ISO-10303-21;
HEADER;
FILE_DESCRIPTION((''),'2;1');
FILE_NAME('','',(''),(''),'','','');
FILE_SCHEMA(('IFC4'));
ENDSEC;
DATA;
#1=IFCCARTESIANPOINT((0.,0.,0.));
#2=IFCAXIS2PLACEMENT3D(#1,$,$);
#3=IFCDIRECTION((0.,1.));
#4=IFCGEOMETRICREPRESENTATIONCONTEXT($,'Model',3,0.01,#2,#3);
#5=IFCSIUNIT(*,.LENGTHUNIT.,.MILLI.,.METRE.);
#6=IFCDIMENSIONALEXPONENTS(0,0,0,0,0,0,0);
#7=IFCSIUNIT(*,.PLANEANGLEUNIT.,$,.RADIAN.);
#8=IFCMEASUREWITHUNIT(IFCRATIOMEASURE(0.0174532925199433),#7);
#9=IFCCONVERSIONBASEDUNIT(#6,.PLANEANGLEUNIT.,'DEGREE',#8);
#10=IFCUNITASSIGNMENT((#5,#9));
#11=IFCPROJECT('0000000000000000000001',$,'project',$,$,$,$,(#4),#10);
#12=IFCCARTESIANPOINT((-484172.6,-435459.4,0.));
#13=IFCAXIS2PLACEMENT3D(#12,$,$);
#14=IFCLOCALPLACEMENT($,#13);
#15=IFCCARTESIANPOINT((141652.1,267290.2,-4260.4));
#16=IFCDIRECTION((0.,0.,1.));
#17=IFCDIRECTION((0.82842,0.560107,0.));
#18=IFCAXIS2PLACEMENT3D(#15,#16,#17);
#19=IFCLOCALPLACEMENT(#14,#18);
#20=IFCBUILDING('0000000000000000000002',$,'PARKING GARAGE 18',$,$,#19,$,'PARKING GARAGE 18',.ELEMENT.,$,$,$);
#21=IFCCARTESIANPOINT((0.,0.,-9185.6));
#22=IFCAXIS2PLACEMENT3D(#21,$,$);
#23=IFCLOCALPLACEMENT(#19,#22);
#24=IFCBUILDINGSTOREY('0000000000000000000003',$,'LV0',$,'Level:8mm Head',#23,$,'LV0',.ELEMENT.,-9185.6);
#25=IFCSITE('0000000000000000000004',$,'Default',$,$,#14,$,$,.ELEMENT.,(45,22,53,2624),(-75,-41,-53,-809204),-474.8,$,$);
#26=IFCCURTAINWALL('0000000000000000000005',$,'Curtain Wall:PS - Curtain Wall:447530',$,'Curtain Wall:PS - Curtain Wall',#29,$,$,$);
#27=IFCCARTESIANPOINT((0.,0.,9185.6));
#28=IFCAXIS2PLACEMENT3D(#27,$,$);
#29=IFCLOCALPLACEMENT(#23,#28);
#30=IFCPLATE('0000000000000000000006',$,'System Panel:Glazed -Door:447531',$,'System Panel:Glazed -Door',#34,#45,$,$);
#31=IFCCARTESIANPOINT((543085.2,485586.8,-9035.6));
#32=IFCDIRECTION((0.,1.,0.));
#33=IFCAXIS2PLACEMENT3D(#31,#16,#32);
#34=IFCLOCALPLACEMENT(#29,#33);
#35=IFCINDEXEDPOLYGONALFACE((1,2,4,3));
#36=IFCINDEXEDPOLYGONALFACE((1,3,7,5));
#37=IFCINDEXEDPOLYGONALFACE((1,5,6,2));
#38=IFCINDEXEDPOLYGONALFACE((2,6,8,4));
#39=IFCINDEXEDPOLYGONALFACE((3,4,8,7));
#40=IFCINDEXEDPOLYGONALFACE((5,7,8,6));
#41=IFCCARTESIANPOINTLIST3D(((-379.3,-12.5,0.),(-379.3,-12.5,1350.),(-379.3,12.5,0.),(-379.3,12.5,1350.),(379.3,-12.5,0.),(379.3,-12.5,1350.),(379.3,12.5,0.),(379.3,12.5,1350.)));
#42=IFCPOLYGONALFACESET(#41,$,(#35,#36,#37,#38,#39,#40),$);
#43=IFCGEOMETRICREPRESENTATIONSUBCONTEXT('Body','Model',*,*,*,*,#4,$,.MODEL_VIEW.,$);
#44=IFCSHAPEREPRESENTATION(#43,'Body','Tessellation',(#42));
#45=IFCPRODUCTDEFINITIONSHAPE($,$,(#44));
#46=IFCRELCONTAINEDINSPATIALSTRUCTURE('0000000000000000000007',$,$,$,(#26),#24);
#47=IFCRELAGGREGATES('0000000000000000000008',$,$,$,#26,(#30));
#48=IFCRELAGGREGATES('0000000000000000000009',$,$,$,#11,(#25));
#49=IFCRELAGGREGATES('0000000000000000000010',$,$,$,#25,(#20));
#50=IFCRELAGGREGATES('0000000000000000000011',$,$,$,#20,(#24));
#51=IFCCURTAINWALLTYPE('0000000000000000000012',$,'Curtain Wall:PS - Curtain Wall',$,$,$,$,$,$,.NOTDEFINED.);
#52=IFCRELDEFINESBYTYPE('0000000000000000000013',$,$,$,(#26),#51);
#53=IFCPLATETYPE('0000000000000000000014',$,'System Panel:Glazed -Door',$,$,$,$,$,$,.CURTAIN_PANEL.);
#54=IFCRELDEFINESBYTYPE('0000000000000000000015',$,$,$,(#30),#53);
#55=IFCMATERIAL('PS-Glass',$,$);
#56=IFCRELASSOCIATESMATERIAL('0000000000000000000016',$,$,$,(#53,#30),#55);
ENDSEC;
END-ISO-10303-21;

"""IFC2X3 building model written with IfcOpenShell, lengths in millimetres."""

from ifc_helpers import new_model, entity, si_unit, converted_unit, direction, frame, origin, origin_2d_with_axis, place, context, subcontext, project, spatial, rectangle, extrude, source, transform, mapped, material, type_object, type_shapes, element, aggregate, save


model = new_model("IFC2X3")

# Units and contexts
model_context = context("Model", 3, precision=0.01, world=origin(), true_north=direction((0.0, 1.0)))
body_context = subcontext(model_context, "Body", "Model", "MODEL_VIEW")
ifc_project = project(units=[si_unit("LENGTHUNIT", "METRE", prefix="MILLI"), converted_unit("PLANEANGLEUNIT", "DEGREE", entity("IfcRatioMeasure", 0.0174532925199433), si_unit("PLANEANGLEUNIT", "RADIAN"), dimensions=[0, 0, 0, 0, 0, 0, 0])], contexts=[model_context])

# Site, building, storey
site_placement = place(None, frame((-484172.6, -435459.4, 0.0)))
site = spatial("IfcSite", under=ifc_project, at=site_placement, Name="Default", CompositionType="ELEMENT", RefLatitude=(45, 22, 53, 2624), RefLongitude=(-75, -41, -53, -809204), RefElevation=-474.8)
building_placement = place(site_placement, frame((141652.1, 267290.2, -4260.4), z_axis=(0.0, 0.0, 1.0), x_axis=(0.82842, 0.560107, 0.0)))
building = spatial("IfcBuilding", under=site, at=building_placement, Name="PARKING GARAGE 18", LongName="PARKING GARAGE 18", CompositionType="ELEMENT")
storey_placement = place(building_placement, frame((0.0, 0.0, -9185.6)))
storey = spatial("IfcBuildingStorey", under=building, at=storey_placement, Name="LV0", ObjectType="Level:8mm Head", LongName="LV0", CompositionType="ELEMENT", Elevation=-9185.6)

# Curtain wall, plate
curtain_wall_type = type_object("IfcCurtainWallType", Name="Curtain Wall:PS - Curtain Wall", PredefinedType="NOTDEFINED")
curtain_wall_placement = place(storey_placement, frame((0.0, 0.0, 9185.6)))
curtain_wall = element("IfcCurtainWall", 1, at=curtain_wall_placement, inside=storey, type_object=curtain_wall_type, Name="Curtain Wall:PS - Curtain Wall:447530", ObjectType="Curtain Wall:PS - Curtain Wall")
ifc_material_1 = material(Name="PS-Glass")
plate_type = type_object("IfcPlateType", Name="System Panel:Glazed -Door", PredefinedType="CURTAIN_PANEL", material=ifc_material_1)
shared_shape = source(origin(), body_context, "Body", "SweptSolid", [
    extrude(rectangle(XDim=25.0, YDim=758.7, at=origin_2d_with_axis()), frame((0.0, 0.0, 0.0), z_axis=(0.0, 0.0, 1.0), x_axis=(0.0, 1.0, 0.0)), (0.0, 0.0, 1.0), 1350.0),
])
type_shapes(plate_type, [shared_shape])
plate_placement = place(curtain_wall_placement, frame((543085.2, 485586.8, -9035.6), z_axis=(0.0, 0.0, 1.0), x_axis=(0.0, 1.0, 0.0)))
plate = element("IfcPlate", 2, at=plate_placement, type_object=plate_type, material=ifc_material_1, Name="System Panel:Glazed -Door:447531", ObjectType="System Panel:Glazed -Door", context=body_context, shape_type="MappedRepresentation", body=[
    mapped(shared_shape, transform((0.0, 0.0, 0.0), scale=1.0)),
])
aggregate(curtain_wall, [plate])

save(model, "model.ifc")
